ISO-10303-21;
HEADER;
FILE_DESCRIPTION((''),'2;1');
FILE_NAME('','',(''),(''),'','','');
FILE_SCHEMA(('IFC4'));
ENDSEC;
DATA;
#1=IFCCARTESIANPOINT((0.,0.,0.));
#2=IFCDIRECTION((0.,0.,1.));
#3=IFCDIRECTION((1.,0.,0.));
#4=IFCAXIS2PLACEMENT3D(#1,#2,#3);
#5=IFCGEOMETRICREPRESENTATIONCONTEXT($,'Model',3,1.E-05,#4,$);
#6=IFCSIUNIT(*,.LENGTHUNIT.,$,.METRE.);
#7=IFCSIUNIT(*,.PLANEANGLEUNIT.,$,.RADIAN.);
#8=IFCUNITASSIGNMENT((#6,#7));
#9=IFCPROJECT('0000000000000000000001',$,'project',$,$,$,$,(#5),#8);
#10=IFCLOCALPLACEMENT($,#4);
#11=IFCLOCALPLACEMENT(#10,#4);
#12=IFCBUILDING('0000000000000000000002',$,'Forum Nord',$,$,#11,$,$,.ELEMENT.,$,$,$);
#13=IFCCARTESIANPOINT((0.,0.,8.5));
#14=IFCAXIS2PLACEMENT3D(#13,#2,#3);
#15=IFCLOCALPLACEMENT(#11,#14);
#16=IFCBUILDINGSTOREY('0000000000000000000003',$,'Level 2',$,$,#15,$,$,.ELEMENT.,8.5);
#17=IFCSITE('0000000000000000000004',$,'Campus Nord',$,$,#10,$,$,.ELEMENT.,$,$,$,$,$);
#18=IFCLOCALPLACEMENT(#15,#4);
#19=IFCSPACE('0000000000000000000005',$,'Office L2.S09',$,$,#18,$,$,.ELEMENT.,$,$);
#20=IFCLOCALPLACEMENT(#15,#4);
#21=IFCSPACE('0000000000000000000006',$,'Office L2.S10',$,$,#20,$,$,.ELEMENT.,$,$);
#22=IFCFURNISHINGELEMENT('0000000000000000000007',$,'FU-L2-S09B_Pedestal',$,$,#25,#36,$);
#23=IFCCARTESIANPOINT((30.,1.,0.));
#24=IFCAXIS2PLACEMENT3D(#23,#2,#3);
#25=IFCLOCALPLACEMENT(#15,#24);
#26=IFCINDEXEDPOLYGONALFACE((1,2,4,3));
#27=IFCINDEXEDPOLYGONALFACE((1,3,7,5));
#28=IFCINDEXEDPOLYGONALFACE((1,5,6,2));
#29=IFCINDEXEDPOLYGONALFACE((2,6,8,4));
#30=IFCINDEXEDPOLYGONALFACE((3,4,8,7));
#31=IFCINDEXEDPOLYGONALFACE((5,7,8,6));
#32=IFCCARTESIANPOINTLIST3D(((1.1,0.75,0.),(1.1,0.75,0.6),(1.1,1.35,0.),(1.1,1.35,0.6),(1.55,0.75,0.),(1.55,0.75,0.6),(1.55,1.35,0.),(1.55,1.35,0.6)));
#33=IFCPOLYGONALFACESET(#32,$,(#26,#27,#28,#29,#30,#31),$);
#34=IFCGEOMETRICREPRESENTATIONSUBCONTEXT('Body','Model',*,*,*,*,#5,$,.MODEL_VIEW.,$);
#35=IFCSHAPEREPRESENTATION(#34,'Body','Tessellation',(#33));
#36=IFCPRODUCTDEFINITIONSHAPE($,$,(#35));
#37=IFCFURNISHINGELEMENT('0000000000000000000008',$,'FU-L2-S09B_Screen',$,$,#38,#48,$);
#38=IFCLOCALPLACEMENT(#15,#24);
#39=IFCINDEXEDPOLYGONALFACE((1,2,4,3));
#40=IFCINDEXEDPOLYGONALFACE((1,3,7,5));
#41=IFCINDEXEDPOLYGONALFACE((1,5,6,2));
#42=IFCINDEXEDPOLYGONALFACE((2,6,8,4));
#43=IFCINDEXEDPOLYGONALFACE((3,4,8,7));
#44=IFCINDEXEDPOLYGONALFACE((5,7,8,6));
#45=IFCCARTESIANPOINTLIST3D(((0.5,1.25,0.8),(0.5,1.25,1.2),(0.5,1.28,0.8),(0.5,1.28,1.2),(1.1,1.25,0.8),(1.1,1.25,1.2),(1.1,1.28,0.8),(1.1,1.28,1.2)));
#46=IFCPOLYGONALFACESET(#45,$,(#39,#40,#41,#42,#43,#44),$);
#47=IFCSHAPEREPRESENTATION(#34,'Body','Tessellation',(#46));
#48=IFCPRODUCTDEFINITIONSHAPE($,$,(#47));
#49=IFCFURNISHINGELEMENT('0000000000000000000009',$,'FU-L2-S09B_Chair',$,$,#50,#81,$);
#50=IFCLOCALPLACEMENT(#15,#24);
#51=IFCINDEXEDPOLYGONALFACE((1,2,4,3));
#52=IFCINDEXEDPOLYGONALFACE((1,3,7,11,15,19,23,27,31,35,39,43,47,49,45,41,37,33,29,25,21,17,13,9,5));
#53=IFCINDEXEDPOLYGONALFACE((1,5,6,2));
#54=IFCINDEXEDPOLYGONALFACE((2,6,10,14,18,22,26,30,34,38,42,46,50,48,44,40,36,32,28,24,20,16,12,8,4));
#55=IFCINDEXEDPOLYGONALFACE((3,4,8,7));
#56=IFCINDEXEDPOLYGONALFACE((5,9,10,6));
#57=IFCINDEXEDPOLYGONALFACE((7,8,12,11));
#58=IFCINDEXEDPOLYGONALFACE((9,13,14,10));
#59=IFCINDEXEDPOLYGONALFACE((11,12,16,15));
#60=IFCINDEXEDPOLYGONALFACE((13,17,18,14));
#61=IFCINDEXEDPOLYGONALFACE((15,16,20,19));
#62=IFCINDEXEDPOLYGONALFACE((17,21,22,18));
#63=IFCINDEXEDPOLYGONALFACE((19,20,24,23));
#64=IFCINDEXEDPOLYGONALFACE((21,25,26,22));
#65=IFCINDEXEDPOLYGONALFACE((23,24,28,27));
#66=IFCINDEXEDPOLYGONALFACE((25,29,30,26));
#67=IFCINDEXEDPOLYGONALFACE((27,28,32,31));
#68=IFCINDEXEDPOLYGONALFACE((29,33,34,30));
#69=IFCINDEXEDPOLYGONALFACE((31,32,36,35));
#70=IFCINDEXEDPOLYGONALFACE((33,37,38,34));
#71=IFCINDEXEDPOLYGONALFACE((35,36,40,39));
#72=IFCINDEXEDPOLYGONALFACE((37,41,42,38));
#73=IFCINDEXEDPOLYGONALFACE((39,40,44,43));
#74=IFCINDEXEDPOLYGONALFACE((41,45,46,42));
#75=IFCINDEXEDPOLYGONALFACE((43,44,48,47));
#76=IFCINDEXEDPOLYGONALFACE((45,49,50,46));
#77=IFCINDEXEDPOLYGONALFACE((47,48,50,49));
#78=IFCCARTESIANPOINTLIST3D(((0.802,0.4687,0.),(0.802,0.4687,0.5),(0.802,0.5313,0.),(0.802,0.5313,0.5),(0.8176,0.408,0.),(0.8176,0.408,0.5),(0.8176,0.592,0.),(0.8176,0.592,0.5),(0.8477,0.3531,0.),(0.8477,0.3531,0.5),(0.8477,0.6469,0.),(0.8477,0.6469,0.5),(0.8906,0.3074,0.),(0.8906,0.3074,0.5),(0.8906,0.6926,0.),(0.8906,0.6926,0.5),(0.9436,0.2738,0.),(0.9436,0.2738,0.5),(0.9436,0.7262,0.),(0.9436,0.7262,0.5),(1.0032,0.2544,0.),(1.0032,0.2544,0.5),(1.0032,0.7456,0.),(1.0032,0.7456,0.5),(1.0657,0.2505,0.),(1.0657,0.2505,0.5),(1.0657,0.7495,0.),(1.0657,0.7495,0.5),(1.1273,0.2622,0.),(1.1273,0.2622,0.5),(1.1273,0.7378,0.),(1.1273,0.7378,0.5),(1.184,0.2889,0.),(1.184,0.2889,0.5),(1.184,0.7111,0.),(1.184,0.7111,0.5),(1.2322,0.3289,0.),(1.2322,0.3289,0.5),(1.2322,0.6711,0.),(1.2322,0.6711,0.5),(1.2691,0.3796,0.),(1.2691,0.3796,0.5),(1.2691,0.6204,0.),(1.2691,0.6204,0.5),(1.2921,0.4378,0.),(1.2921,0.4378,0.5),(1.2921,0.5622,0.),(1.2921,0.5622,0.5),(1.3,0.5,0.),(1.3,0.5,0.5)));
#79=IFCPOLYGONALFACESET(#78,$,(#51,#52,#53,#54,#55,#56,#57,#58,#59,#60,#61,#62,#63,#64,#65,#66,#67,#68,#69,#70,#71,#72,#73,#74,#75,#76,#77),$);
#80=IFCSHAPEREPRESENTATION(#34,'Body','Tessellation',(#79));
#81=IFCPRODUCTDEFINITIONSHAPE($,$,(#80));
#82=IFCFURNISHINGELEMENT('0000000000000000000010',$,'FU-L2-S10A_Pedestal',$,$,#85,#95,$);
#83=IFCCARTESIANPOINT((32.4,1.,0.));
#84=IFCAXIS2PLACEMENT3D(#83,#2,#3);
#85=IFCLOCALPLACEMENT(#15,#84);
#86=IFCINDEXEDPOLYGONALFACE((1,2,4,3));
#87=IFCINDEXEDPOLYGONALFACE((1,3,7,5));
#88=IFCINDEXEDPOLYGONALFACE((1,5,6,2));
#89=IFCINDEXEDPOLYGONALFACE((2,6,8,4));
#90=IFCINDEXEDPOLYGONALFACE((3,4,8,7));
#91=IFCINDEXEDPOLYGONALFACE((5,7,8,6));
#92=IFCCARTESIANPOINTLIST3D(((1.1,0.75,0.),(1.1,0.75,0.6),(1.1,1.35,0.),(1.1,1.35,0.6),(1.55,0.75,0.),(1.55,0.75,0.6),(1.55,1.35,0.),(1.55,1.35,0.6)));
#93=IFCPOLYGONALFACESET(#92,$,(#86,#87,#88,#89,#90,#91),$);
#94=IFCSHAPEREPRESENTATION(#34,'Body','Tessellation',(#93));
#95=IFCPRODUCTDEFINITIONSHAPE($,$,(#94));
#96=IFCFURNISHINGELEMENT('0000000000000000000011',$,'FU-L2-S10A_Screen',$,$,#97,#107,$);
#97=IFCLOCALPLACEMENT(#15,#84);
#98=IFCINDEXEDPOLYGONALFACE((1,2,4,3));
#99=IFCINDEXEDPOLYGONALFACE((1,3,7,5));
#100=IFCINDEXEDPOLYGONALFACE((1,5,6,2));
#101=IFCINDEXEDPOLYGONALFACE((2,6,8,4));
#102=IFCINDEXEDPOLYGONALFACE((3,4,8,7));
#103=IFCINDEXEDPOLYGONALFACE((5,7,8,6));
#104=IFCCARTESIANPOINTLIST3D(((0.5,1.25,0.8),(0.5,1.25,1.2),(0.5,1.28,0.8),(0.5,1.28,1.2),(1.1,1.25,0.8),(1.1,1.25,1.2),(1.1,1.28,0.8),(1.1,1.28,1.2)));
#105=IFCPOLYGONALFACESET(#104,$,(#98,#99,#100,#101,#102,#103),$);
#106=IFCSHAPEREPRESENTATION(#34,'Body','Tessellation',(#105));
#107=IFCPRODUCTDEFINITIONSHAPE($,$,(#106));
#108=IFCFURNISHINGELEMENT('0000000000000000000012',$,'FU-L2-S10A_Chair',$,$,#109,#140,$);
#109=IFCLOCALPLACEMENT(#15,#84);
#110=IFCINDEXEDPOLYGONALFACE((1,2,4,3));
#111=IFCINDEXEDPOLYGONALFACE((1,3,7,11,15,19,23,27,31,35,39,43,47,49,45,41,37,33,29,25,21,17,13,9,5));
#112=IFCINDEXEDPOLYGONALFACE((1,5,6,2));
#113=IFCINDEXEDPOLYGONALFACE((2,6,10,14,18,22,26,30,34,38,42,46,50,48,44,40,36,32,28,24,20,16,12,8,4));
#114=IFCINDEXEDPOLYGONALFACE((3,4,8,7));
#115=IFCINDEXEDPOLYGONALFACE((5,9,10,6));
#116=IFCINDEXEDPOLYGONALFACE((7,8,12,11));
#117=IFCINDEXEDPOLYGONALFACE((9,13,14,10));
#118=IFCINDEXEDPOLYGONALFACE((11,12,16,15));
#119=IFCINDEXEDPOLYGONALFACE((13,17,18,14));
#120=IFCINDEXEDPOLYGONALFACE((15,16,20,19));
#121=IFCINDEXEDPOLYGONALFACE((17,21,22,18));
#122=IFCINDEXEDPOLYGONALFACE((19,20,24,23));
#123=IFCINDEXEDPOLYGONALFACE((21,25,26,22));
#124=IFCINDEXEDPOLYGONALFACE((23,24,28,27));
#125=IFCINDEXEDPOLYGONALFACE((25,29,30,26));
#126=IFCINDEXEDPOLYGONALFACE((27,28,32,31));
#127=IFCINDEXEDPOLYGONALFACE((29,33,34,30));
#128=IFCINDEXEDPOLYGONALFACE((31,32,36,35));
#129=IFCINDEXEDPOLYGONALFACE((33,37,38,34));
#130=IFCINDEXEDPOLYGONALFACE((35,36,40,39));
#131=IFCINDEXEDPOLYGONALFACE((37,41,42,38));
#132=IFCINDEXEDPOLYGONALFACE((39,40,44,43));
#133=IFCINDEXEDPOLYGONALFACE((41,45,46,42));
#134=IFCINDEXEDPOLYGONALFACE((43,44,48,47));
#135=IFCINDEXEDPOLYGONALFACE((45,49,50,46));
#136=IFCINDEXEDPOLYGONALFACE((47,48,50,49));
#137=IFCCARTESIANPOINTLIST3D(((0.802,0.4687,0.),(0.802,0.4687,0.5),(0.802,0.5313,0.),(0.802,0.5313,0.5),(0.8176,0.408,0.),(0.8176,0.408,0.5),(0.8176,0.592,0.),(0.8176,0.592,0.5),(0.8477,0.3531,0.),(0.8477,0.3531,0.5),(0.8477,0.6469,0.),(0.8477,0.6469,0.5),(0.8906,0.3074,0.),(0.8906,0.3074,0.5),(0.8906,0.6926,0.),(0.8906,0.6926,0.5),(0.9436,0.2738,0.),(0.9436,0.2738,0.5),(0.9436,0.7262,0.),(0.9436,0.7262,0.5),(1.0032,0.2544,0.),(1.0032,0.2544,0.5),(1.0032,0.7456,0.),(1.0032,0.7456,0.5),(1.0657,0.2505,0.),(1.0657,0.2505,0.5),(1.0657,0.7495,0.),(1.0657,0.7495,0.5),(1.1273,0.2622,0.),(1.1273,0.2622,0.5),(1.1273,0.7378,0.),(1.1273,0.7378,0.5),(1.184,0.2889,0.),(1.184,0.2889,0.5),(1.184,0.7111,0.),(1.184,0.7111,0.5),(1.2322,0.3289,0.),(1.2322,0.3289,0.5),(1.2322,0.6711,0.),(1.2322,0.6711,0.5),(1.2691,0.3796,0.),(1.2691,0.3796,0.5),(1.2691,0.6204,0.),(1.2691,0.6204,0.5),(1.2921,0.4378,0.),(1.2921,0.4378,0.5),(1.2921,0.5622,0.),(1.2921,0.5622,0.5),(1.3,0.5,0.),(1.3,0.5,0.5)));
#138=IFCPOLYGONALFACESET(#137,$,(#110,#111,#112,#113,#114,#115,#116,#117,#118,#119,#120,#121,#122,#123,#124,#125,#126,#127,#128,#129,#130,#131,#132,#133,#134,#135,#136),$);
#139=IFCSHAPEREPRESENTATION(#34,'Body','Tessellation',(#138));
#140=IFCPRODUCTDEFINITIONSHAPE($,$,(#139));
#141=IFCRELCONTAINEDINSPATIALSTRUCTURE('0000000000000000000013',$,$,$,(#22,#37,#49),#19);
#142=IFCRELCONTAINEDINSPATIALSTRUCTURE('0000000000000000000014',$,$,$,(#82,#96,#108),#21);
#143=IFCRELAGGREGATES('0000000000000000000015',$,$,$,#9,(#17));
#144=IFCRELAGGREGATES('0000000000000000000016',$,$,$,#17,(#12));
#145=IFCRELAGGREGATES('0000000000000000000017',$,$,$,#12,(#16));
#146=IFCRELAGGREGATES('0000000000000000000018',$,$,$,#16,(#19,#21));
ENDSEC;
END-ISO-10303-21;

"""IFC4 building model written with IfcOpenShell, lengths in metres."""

from ifc_helpers import new_model, si_unit, frame, frame_2d, origin_with_axes, place, context, subcontext, project, spatial, rectangle, circle, extrude, element, save


model = new_model("IFC4")

# Units and contexts
model_context = context("Model", 3, precision=1e-05, world=origin_with_axes())
body_context = subcontext(model_context, "Body", "Model", "MODEL_VIEW")
ifc_project = project(units=[si_unit("LENGTHUNIT", "METRE"), si_unit("PLANEANGLEUNIT", "RADIAN")], contexts=[model_context])

# Site, building, storey
site_placement = place(None, origin_with_axes())
site = spatial("IfcSite", under=ifc_project, at=site_placement, Name="Campus Nord", CompositionType="ELEMENT")
building_placement = place(site_placement, origin_with_axes())
building = spatial("IfcBuilding", under=site, at=building_placement, Name="Forum Nord", CompositionType="ELEMENT")
storey_placement = place(building_placement, frame((0.0, 0.0, 8.5), z_axis=(0.0, 0.0, 1.0), x_axis=(1.0, 0.0, 0.0)))
storey = spatial("IfcBuildingStorey", under=building, at=storey_placement, Name="Level 2", CompositionType="ELEMENT", Elevation=8.5)

# Shared definitions
space_1_placement = place(storey_placement, origin_with_axes())
space_1 = spatial("IfcSpace", under=storey, at=space_1_placement, Name="Office L2.S09", CompositionType="ELEMENT")

# Furnishing elements
furnishing_1_placement = place(storey_placement, frame((30.0, 1.0, 0.0), z_axis=(0.0, 0.0, 1.0), x_axis=(1.0, 0.0, 0.0)))
element("IfcFurnishingElement", 1, at=furnishing_1_placement, inside=space_1, Name="FU-L2-S09B_Pedestal", context=body_context, shape_type="SweptSolid", body=[
    extrude(rectangle(XDim=0.45, YDim=0.6, at=frame_2d((1.325, 1.05), x_axis=(1.0, 0.0))), origin_with_axes(), (0.0, 0.0, 1.0), 0.6),
])
furnishing_2_placement = place(storey_placement, frame((30.0, 1.0, 0.0), z_axis=(0.0, 0.0, 1.0), x_axis=(1.0, 0.0, 0.0)))
element("IfcFurnishingElement", 2, at=furnishing_2_placement, inside=space_1, Name="FU-L2-S09B_Screen", context=body_context, shape_type="SweptSolid", body=[
    extrude(rectangle(XDim=0.6, YDim=0.03, at=frame_2d((0.8, 1.265), x_axis=(1.0, 0.0))), frame((0.0, 0.0, 0.8), z_axis=(0.0, 0.0, 1.0), x_axis=(1.0, 0.0, 0.0)), (0.0, 0.0, 1.0), 0.4),
])
furnishing_3_placement = place(storey_placement, frame((30.0, 1.0, 0.0), z_axis=(0.0, 0.0, 1.0), x_axis=(1.0, 0.0, 0.0)))
element("IfcFurnishingElement", 3, at=furnishing_3_placement, inside=space_1, Name="FU-L2-S09B_Chair", context=body_context, shape_type="SweptSolid", body=[
    extrude(circle(Radius=0.25, at=frame_2d((1.05, 0.5), x_axis=(1.0, 0.0))), origin_with_axes(), (0.0, 0.0, 1.0), 0.5),
])

# Shared definitions
space_2_placement = place(storey_placement, origin_with_axes())
space_2 = spatial("IfcSpace", under=storey, at=space_2_placement, Name="Office L2.S10", CompositionType="ELEMENT")

# Furnishing elements
furnishing_4_placement = place(storey_placement, frame((32.4, 1.0, 0.0), z_axis=(0.0, 0.0, 1.0), x_axis=(1.0, 0.0, 0.0)))
element("IfcFurnishingElement", 4, at=furnishing_4_placement, inside=space_2, Name="FU-L2-S10A_Pedestal", context=body_context, shape_type="SweptSolid", body=[
    extrude(rectangle(XDim=0.45, YDim=0.6, at=frame_2d((1.325, 1.05), x_axis=(1.0, 0.0))), origin_with_axes(), (0.0, 0.0, 1.0), 0.6),
])
furnishing_5_placement = place(storey_placement, frame((32.4, 1.0, 0.0), z_axis=(0.0, 0.0, 1.0), x_axis=(1.0, 0.0, 0.0)))
element("IfcFurnishingElement", 5, at=furnishing_5_placement, inside=space_2, Name="FU-L2-S10A_Screen", context=body_context, shape_type="SweptSolid", body=[
    extrude(rectangle(XDim=0.6, YDim=0.03, at=frame_2d((0.8, 1.265), x_axis=(1.0, 0.0))), frame((0.0, 0.0, 0.8), z_axis=(0.0, 0.0, 1.0), x_axis=(1.0, 0.0, 0.0)), (0.0, 0.0, 1.0), 0.4),
])
furnishing_6_placement = place(storey_placement, frame((32.4, 1.0, 0.0), z_axis=(0.0, 0.0, 1.0), x_axis=(1.0, 0.0, 0.0)))
element("IfcFurnishingElement", 6, at=furnishing_6_placement, inside=space_2, Name="FU-L2-S10A_Chair", context=body_context, shape_type="SweptSolid", body=[
    extrude(circle(Radius=0.25, at=frame_2d((1.05, 0.5), x_axis=(1.0, 0.0))), origin_with_axes(), (0.0, 0.0, 1.0), 0.5),
])

save(model, "model.ifc")
